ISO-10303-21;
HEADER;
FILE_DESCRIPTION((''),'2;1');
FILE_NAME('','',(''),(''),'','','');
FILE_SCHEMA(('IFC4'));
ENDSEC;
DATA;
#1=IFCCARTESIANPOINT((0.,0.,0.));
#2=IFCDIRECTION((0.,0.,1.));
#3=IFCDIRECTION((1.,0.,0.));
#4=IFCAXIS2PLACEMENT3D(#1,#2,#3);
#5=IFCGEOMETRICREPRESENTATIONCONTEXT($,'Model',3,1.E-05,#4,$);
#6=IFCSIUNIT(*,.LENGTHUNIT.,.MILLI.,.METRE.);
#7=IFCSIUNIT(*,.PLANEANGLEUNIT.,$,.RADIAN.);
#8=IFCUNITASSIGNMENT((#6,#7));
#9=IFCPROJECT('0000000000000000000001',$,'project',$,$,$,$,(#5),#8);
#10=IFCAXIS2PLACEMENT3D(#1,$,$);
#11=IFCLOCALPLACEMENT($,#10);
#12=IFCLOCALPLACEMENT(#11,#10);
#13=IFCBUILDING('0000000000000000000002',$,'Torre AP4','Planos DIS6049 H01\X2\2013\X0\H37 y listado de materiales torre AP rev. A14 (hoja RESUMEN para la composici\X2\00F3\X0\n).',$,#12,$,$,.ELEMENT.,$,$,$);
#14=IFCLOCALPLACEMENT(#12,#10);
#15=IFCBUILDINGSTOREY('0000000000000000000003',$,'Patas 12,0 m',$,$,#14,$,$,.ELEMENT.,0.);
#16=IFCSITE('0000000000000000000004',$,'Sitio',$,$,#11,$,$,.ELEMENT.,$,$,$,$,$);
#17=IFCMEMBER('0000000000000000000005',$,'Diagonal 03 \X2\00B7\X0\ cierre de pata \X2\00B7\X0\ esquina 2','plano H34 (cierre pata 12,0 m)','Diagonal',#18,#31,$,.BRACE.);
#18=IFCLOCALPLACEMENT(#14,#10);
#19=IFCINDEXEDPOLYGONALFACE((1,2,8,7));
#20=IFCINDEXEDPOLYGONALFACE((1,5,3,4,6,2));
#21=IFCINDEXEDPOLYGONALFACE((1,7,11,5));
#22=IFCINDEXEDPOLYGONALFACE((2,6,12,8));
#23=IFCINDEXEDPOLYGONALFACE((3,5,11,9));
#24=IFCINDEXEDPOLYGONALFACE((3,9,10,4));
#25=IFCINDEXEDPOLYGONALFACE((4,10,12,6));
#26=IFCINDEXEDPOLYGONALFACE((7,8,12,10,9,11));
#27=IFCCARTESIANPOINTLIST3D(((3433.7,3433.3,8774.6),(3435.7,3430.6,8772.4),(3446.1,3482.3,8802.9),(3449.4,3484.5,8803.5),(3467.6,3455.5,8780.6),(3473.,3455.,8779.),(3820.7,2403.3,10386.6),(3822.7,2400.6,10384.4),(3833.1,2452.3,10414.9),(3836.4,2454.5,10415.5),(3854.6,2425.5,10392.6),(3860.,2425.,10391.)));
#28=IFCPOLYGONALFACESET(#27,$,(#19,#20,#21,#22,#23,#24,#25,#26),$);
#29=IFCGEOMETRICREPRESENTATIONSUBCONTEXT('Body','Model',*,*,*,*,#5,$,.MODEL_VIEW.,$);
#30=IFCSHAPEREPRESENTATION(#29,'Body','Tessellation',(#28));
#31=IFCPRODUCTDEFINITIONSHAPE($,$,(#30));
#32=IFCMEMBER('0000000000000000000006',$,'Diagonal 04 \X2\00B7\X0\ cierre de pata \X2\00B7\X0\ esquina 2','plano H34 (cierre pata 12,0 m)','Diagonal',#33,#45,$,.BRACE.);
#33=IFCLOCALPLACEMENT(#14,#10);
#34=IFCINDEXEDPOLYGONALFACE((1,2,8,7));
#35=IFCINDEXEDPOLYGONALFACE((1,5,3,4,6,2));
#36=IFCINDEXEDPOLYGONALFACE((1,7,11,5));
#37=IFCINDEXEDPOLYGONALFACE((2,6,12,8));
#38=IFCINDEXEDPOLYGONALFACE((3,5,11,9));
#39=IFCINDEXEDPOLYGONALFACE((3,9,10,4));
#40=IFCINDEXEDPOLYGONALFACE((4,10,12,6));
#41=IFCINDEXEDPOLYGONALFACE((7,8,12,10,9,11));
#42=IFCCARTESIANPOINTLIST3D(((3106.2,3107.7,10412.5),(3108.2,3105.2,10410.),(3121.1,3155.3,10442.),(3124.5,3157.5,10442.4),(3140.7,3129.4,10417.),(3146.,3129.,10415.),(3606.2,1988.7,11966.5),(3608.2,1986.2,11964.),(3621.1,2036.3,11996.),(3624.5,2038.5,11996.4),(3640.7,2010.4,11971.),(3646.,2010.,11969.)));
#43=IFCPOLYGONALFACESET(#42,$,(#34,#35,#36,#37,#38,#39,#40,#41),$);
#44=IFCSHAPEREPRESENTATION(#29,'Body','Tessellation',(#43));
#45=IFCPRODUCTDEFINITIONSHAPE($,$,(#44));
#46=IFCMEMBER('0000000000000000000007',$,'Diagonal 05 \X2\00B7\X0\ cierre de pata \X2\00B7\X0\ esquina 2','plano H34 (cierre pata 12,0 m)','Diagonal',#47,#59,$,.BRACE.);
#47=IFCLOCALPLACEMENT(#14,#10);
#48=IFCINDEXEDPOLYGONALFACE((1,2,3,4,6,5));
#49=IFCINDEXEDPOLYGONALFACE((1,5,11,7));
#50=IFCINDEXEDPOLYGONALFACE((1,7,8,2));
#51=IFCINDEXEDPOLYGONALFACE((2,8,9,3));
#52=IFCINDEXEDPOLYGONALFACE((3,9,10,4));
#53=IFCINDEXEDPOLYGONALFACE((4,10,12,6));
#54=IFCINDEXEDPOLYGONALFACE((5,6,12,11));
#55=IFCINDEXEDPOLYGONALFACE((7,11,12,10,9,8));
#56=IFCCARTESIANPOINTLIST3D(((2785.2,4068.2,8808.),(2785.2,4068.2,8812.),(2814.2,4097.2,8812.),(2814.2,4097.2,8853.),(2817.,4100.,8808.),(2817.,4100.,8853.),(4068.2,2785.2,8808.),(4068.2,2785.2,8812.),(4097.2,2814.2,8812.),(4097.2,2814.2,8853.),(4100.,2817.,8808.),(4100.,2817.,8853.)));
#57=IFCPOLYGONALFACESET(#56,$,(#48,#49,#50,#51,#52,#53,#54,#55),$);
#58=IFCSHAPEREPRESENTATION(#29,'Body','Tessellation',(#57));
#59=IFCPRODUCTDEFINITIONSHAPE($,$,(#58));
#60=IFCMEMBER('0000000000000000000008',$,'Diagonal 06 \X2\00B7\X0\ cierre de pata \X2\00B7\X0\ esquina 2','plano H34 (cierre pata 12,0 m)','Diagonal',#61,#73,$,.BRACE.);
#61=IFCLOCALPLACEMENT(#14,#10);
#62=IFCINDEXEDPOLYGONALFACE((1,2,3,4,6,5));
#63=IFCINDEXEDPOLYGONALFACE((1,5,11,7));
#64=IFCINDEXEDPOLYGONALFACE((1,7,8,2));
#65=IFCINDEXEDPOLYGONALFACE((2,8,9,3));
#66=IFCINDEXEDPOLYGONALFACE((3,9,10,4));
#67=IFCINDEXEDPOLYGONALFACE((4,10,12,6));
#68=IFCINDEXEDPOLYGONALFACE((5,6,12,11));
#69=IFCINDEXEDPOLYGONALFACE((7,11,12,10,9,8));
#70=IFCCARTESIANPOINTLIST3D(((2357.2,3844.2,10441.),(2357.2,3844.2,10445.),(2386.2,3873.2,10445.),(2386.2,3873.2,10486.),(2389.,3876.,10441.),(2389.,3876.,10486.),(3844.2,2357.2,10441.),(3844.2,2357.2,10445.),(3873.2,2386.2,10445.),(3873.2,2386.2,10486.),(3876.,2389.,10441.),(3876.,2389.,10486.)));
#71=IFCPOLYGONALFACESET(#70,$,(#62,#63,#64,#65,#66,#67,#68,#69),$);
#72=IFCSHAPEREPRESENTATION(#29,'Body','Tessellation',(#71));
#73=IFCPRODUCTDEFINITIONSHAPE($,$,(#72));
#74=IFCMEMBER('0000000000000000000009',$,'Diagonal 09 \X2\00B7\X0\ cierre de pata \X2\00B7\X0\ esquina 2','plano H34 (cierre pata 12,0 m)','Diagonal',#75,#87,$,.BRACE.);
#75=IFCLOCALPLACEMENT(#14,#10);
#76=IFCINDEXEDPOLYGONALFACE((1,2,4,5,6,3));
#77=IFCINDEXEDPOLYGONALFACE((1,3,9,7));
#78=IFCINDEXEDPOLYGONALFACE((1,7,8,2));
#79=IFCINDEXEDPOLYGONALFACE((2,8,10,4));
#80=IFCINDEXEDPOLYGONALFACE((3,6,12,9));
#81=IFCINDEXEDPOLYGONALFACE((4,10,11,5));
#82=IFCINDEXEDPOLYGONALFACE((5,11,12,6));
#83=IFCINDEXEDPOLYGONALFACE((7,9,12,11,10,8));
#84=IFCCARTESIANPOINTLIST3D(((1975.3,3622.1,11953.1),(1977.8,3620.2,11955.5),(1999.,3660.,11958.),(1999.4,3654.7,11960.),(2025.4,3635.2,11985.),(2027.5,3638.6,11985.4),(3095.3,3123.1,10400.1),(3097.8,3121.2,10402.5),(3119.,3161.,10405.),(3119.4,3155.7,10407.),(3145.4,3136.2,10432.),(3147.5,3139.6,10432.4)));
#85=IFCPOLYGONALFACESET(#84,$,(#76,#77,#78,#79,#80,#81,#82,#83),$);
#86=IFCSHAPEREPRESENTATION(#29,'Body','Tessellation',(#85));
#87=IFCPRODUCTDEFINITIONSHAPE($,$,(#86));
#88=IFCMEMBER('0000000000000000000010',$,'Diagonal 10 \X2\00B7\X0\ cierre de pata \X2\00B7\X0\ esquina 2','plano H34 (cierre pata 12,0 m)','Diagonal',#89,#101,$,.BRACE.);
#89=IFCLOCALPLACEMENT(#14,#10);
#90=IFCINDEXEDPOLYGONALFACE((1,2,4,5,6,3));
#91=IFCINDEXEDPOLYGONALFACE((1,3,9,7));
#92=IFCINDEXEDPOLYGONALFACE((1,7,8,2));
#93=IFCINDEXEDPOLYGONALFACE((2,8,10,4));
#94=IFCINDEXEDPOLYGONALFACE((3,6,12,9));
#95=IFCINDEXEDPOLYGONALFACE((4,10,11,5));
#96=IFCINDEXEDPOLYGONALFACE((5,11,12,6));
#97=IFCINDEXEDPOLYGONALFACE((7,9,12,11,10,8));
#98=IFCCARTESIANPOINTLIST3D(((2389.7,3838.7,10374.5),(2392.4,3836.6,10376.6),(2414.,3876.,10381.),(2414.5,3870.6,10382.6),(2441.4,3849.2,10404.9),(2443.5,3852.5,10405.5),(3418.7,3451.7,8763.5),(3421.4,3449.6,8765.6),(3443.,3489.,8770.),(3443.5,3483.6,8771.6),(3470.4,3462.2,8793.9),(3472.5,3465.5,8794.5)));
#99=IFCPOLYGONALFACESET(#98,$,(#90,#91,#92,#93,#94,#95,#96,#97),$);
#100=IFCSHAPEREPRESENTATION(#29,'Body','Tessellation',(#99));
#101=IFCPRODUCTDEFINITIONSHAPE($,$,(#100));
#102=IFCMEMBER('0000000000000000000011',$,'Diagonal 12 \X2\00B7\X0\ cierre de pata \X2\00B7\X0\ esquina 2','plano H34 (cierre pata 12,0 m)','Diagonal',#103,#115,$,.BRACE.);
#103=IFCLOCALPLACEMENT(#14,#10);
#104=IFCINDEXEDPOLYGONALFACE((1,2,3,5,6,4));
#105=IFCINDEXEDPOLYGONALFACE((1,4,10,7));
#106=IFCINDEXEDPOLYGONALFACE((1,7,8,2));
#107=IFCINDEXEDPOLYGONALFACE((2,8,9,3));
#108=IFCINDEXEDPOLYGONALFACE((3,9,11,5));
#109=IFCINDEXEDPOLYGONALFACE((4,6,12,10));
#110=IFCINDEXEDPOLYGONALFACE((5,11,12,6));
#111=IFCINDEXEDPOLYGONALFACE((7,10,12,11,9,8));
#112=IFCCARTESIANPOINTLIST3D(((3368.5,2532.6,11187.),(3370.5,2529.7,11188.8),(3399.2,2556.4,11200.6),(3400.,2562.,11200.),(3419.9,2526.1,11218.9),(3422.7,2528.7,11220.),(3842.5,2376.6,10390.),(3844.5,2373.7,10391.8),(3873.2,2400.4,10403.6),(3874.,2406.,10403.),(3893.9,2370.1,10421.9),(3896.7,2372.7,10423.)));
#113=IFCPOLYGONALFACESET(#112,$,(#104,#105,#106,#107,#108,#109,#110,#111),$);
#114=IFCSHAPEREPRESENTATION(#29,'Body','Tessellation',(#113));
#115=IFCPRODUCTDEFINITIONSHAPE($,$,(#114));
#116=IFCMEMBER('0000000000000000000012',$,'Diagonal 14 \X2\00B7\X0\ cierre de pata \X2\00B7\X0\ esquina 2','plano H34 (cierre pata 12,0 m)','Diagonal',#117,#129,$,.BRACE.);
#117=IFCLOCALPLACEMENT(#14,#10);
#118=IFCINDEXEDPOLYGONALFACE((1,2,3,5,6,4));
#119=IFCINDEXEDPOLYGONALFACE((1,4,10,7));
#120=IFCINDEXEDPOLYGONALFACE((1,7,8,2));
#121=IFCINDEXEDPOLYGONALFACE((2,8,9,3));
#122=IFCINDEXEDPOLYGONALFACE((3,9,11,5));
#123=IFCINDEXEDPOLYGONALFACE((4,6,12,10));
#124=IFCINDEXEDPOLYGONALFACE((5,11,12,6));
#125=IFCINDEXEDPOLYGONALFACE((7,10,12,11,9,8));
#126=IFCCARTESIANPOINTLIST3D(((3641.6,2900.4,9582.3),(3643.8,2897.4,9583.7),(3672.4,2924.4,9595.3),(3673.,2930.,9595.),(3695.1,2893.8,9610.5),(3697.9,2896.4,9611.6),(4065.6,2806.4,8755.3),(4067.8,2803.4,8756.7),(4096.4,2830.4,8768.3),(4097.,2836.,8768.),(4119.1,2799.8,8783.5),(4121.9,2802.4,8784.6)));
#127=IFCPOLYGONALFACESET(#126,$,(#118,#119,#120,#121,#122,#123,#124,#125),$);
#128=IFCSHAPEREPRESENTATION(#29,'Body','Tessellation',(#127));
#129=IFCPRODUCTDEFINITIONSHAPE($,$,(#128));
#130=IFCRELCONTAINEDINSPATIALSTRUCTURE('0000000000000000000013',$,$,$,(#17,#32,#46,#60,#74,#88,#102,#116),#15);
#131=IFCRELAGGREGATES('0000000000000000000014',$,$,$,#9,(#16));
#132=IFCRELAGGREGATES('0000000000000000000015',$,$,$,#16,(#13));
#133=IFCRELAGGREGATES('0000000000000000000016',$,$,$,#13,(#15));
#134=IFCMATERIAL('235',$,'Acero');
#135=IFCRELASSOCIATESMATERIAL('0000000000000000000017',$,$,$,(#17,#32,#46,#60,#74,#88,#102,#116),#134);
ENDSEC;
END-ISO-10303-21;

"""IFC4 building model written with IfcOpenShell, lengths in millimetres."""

from ifc_helpers import new_model, si_unit, frame, frame_2d, origin, origin_with_axes, place, context, subcontext, project, spatial, l_section, extrude, material, element, save


model = new_model("IFC4")

# Units and contexts
model_context = context("Model", 3, precision=1e-05, world=origin_with_axes())
body_context = subcontext(model_context, "Body", "Model", "MODEL_VIEW")
ifc_project = project(units=[si_unit("LENGTHUNIT", "METRE", prefix="MILLI"), si_unit("PLANEANGLEUNIT", "RADIAN")], contexts=[model_context])

# Site, building, storey
site_placement = place(None, origin())
site = spatial("IfcSite", under=ifc_project, at=site_placement, Name="Sitio", CompositionType="ELEMENT")
building_placement = place(site_placement, origin())
building = spatial("IfcBuilding", under=site, at=building_placement, Name="Torre AP4", Description="Planos DIS6049 H01–H37 y listado de materiales torre AP rev. A14 (hoja RESUMEN para la composición).", CompositionType="ELEMENT")
storey_placement = place(building_placement, origin())
storey = spatial("IfcBuildingStorey", under=building, at=storey_placement, Name="Patas 12,0 m", CompositionType="ELEMENT", Elevation=0.0)

# Members
ifc_material_1 = material(Name="235", Category="Acero")
member_1_placement = place(storey_placement, frame((3860.0, 2425.0, 10391.0), z_axis=(-0.198287, 0.527739, -0.825938), x_axis=(-0.827791, -0.541385, -0.14719)))
element("IfcMember", 1, at=member_1_placement, inside=storey, material=ifc_material_1, Name="Diagonal 03 · cierre de pata · esquina 2", Description="plano H34 (cierre pata 12,0 m)", ObjectType="Diagonal", PredefinedType="BRACE", context=body_context, shape_type="SweptSolid", body=[
    extrude(l_section(Depth=45.0, Width=45.0, Thickness=4.0, at=frame_2d((22.5, 22.5))), None, (0.0, 0.0, 1.0), 1951.7),
])
member_2_placement = place(storey_placement, frame((3646.0, 2010.0, 11969.0), z_axis=(-0.252632, 0.565391, -0.785181), x_axis=(-0.840989, -0.529594, -0.11076)))
element("IfcMember", 2, at=member_2_placement, inside=storey, material=ifc_material_1, Name="Diagonal 04 · cierre de pata · esquina 2", Description="plano H34 (cierre pata 12,0 m)", ObjectType="Diagonal", PredefinedType="BRACE", context=body_context, shape_type="SweptSolid", body=[
    extrude(l_section(Depth=45.0, Width=45.0, Thickness=4.0, at=frame_2d((22.5, 22.5))), None, (0.0, 0.0, 1.0), 1979.2),
])
member_3_placement = place(storey_placement, frame((4100.0, 2817.0, 8808.0), z_axis=(-0.707107, 0.707107, 0.0), x_axis=(-0.707107, -0.707107, 0.0)))
element("IfcMember", 3, at=member_3_placement, inside=storey, material=ifc_material_1, Name="Diagonal 05 · cierre de pata · esquina 2", Description="plano H34 (cierre pata 12,0 m)", ObjectType="Diagonal", PredefinedType="BRACE", context=body_context, shape_type="SweptSolid", body=[
    extrude(l_section(Depth=45.0, Width=45.0, Thickness=4.0, at=frame_2d((22.5, 22.5))), None, (0.0, 0.0, 1.0), 1814.4),
])
member_4_placement = place(storey_placement, frame((3876.0, 2389.0, 10441.0), z_axis=(-0.707107, 0.707107, 0.0), x_axis=(-0.707107, -0.707107, 0.0)))
element("IfcMember", 4, at=member_4_placement, inside=storey, material=ifc_material_1, Name="Diagonal 06 · cierre de pata · esquina 2", Description="plano H34 (cierre pata 12,0 m)", ObjectType="Diagonal", PredefinedType="BRACE", context=body_context, shape_type="SweptSolid", body=[
    extrude(l_section(Depth=45.0, Width=45.0, Thickness=4.0, at=frame_2d((22.5, 22.5))), None, (0.0, 0.0, 1.0), 2102.9),
])
member_5_placement = place(storey_placement, frame((3119.0, 3161.0, 10405.0), z_axis=(-0.566031, 0.252187, 0.784863), x_axis=(-0.527101, -0.842737, -0.109355)))
element("IfcMember", 5, at=member_5_placement, inside=storey, material=ifc_material_1, Name="Diagonal 09 · cierre de pata · esquina 2", Description="plano H34 (cierre pata 12,0 m)", ObjectType="Diagonal", PredefinedType="BRACE", context=body_context, shape_type="SweptSolid", body=[
    extrude(l_section(Depth=45.0, Width=45.0, Thickness=4.0, at=frame_2d((22.5, 22.5))), None, (0.0, 0.0, 1.0), 1978.7),
])
member_6_placement = place(storey_placement, frame((3443.0, 3489.0, 8770.0), z_axis=(-0.527593, 0.198424, 0.825998), x_axis=(-0.539245, -0.829544, -0.145158)))
element("IfcMember", 6, at=member_6_placement, inside=storey, material=ifc_material_1, Name="Diagonal 10 · cierre de pata · esquina 2", Description="plano H34 (cierre pata 12,0 m)", ObjectType="Diagonal", PredefinedType="BRACE", context=body_context, shape_type="SweptSolid", body=[
    extrude(l_section(Depth=45.0, Width=45.0, Thickness=4.0, at=frame_2d((22.5, 22.5))), None, (0.0, 0.0, 1.0), 1950.4),
])
member_7_placement = place(storey_placement, frame((3874.0, 2406.0, 10403.0), z_axis=(-0.504078, 0.165899, 0.847575), x_axis=(-0.700597, -0.652429, -0.288964)))
element("IfcMember", 7, at=member_7_placement, inside=storey, material=ifc_material_1, Name="Diagonal 12 · cierre de pata · esquina 2", Description="plano H34 (cierre pata 12,0 m)", ObjectType="Diagonal", PredefinedType="BRACE", context=body_context, shape_type="SweptSolid", body=[
    extrude(l_section(Depth=45.0, Width=45.0, Thickness=4.0, at=frame_2d((22.5, 22.5))), None, (0.0, 0.0, 1.0), 940.3),
])
member_8_placement = place(storey_placement, frame((4097.0, 2836.0, 8768.0), z_axis=(-0.453913, 0.100632, 0.885345), x_axis=(-0.697959, -0.657818, -0.283071)))
element("IfcMember", 8, at=member_8_placement, inside=storey, material=ifc_material_1, Name="Diagonal 14 · cierre de pata · esquina 2", Description="plano H34 (cierre pata 12,0 m)", ObjectType="Diagonal", PredefinedType="BRACE", context=body_context, shape_type="SweptSolid", body=[
    extrude(l_section(Depth=45.0, Width=45.0, Thickness=4.0, at=frame_2d((22.5, 22.5))), None, (0.0, 0.0, 1.0), 934.1),
])

save(model, "model.ifc")
